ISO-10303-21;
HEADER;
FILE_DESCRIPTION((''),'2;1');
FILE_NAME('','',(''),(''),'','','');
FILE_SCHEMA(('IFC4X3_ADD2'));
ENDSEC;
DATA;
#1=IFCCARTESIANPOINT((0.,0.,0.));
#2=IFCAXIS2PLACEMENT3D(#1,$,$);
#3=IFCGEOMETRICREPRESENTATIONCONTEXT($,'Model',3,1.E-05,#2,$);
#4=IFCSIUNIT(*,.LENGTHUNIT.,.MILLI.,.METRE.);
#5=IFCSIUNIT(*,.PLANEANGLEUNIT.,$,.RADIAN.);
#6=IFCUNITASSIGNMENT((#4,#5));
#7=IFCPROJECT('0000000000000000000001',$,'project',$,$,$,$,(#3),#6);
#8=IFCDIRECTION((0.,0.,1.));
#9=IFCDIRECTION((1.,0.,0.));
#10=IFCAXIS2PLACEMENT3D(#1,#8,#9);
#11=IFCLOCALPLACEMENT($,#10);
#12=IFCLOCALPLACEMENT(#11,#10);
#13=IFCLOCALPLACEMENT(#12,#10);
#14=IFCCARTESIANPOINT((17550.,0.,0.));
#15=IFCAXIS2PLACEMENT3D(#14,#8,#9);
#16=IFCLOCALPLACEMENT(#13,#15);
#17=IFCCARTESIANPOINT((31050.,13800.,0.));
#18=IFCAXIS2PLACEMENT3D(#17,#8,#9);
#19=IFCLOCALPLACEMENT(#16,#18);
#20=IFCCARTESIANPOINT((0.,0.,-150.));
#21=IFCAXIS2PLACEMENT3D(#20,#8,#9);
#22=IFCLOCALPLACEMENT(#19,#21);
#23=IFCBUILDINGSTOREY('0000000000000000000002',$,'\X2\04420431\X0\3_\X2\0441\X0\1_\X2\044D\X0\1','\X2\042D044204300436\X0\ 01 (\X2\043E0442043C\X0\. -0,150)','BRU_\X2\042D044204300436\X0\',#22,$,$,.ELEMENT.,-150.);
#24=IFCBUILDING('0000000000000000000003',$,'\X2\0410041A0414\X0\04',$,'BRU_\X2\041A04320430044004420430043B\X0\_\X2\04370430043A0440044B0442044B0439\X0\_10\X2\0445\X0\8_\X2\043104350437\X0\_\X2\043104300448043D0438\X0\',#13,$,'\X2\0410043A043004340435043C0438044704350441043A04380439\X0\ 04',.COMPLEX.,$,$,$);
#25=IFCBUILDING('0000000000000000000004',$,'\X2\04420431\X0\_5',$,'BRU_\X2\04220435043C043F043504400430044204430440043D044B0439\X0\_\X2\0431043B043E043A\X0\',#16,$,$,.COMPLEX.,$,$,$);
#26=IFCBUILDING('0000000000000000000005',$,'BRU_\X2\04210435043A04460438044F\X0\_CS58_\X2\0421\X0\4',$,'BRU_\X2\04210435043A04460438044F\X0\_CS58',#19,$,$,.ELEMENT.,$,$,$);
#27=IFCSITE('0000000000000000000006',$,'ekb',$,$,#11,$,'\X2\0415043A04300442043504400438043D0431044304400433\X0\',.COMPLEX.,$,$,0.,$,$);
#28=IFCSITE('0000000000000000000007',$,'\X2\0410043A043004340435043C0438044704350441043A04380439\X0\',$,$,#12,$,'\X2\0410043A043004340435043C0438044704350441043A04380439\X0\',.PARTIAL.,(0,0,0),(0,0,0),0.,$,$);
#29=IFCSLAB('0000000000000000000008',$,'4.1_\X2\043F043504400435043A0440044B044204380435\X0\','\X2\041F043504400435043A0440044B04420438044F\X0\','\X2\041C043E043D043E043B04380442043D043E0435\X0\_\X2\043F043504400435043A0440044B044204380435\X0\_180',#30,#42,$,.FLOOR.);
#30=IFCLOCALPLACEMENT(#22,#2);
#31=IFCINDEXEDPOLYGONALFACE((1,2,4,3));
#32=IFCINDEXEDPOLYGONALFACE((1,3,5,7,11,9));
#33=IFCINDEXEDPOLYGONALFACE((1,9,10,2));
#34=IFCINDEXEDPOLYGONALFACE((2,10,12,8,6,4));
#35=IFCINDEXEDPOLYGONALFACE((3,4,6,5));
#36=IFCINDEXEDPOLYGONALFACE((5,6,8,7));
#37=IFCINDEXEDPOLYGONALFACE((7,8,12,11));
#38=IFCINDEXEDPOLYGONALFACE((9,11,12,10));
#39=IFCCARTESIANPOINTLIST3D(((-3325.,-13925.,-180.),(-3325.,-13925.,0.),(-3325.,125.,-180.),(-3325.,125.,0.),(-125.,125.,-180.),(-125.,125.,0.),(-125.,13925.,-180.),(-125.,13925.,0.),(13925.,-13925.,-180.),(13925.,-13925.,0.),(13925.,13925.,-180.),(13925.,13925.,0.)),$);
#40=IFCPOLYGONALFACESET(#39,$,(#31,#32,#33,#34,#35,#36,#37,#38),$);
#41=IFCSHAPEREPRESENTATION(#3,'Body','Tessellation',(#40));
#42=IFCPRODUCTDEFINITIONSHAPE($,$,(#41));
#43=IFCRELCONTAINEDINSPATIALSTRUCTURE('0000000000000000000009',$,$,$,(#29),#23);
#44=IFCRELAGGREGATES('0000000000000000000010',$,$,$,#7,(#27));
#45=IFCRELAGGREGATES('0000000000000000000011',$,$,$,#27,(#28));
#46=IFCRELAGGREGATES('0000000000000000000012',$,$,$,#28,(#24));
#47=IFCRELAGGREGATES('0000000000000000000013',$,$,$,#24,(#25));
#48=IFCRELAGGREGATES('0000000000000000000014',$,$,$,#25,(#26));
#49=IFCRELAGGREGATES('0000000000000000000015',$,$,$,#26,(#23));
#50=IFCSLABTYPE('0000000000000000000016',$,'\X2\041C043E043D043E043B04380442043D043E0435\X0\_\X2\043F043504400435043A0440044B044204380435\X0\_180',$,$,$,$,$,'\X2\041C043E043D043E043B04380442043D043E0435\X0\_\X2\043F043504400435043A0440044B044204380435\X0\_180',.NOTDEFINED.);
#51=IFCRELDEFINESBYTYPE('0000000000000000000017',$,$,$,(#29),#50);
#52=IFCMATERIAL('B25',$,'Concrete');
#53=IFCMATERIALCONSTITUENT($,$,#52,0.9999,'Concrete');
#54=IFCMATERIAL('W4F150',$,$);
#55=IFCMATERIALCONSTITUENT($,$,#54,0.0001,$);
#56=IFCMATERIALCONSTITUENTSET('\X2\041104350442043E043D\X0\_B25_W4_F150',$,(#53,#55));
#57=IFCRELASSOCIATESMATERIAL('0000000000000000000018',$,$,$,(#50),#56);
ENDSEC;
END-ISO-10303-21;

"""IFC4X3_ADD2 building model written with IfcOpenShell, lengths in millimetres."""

from ifc_helpers import new_model, si_unit, frame, origin, origin_with_axes, place, context, project, spatial, polyline, outline, extrude, material, constituent, constituent_set, type_object, element, save


model = new_model("IFC4X3_ADD2")

# Units and contexts
model_context = context("Model", 3, precision=1e-05, world=origin())
ifc_project = project(units=[si_unit("LENGTHUNIT", "METRE", prefix="MILLI"), si_unit("PLANEANGLEUNIT", "RADIAN")], contexts=[model_context])

# Sites, buildings, storey
site_1_placement = place(None, origin_with_axes())
site_1 = spatial("IfcSite", under=ifc_project, at=site_1_placement, Name="ekb", LongName="Екатеринбург", CompositionType="COMPLEX", RefElevation=0.0)
site_2_placement = place(site_1_placement, origin_with_axes())
site_2 = spatial("IfcSite", under=site_1, at=site_2_placement, Name="Академический", LongName="Академический", CompositionType="PARTIAL", RefLatitude=(0, 0, 0), RefLongitude=(0, 0, 0), RefElevation=0.0)
building_1_placement = place(site_2_placement, origin_with_axes())
building_1 = spatial("IfcBuilding", under=site_2, at=building_1_placement, Name="АКД04", ObjectType="BRU_Квартал_закрытый_10х8_без_башни", LongName="Академический 04", CompositionType="COMPLEX")
building_2_placement = place(building_1_placement, frame((17550.0, 0.0, 0.0), z_axis=(0.0, 0.0, 1.0), x_axis=(1.0, 0.0, 0.0)))
building_2 = spatial("IfcBuilding", under=building_1, at=building_2_placement, Name="тб_5", ObjectType="BRU_Температурный_блок", CompositionType="COMPLEX")
building_3_placement = place(building_2_placement, frame((31050.0, 13800.0, 0.0), z_axis=(0.0, 0.0, 1.0), x_axis=(1.0, 0.0, 0.0)))
building_3 = spatial("IfcBuilding", under=building_2, at=building_3_placement, Name="BRU_Секция_CS58_С4", ObjectType="BRU_Секция_CS58", CompositionType="ELEMENT")
storey_placement = place(building_3_placement, frame((0.0, 0.0, -150.0), z_axis=(0.0, 0.0, 1.0), x_axis=(1.0, 0.0, 0.0)))
storey = spatial("IfcBuildingStorey", under=building_3, at=storey_placement, Name="тб3_с1_э1", Description="Этаж 01 (отм. -0,150)", ObjectType="BRU_Этаж", CompositionType="ELEMENT", Elevation=-150.0)

# Shared definitions
ifc_material_1 = material(Name="B25", Category="Concrete")
ifc_material_2 = material(Name="W4F150")

# Slab
ifc_constituent_1 = constituent(ifc_material_1, Category="Concrete", fraction=0.9999)
ifc_constituent_2 = constituent(ifc_material_2, fraction=0.0001)
ifc_constituent_set_1 = constituent_set(constituents=[ifc_constituent_1, ifc_constituent_2], Name="Бетон_B25_W4_F150")
slab_type = type_object("IfcSlabType", Name="Монолитное_перекрытие_180", ElementType="Монолитное_перекрытие_180", PredefinedType="NOTDEFINED", material=ifc_constituent_set_1)
slab_placement = place(storey_placement, frame((0.0, 0.0, -180.0), z_axis=(0.0, 0.0, 1.0), x_axis=(1.0, 0.0, 0.0)))
element("IfcSlab", 1, at=slab_placement, inside=storey, type_object=slab_type, Name="4.1_перекрытие", Description="Перекрытия", ObjectType="Монолитное_перекрытие_180", PredefinedType="FLOOR", context=model_context, shape_type="SweptSolid", body=[
    extrude(outline(polyline([(13925.0, -13925.0), (13925.0, 13925.0), (-125.0, 13925.0), (-125.0, 125.0), (-3325.0, 125.0), (-3325.0, -13925.0), (13925.0, -13925.0)])), origin_with_axes(), (0.0, 0.0, 1.0), 180.0),
])

save(model, "model.ifc")
